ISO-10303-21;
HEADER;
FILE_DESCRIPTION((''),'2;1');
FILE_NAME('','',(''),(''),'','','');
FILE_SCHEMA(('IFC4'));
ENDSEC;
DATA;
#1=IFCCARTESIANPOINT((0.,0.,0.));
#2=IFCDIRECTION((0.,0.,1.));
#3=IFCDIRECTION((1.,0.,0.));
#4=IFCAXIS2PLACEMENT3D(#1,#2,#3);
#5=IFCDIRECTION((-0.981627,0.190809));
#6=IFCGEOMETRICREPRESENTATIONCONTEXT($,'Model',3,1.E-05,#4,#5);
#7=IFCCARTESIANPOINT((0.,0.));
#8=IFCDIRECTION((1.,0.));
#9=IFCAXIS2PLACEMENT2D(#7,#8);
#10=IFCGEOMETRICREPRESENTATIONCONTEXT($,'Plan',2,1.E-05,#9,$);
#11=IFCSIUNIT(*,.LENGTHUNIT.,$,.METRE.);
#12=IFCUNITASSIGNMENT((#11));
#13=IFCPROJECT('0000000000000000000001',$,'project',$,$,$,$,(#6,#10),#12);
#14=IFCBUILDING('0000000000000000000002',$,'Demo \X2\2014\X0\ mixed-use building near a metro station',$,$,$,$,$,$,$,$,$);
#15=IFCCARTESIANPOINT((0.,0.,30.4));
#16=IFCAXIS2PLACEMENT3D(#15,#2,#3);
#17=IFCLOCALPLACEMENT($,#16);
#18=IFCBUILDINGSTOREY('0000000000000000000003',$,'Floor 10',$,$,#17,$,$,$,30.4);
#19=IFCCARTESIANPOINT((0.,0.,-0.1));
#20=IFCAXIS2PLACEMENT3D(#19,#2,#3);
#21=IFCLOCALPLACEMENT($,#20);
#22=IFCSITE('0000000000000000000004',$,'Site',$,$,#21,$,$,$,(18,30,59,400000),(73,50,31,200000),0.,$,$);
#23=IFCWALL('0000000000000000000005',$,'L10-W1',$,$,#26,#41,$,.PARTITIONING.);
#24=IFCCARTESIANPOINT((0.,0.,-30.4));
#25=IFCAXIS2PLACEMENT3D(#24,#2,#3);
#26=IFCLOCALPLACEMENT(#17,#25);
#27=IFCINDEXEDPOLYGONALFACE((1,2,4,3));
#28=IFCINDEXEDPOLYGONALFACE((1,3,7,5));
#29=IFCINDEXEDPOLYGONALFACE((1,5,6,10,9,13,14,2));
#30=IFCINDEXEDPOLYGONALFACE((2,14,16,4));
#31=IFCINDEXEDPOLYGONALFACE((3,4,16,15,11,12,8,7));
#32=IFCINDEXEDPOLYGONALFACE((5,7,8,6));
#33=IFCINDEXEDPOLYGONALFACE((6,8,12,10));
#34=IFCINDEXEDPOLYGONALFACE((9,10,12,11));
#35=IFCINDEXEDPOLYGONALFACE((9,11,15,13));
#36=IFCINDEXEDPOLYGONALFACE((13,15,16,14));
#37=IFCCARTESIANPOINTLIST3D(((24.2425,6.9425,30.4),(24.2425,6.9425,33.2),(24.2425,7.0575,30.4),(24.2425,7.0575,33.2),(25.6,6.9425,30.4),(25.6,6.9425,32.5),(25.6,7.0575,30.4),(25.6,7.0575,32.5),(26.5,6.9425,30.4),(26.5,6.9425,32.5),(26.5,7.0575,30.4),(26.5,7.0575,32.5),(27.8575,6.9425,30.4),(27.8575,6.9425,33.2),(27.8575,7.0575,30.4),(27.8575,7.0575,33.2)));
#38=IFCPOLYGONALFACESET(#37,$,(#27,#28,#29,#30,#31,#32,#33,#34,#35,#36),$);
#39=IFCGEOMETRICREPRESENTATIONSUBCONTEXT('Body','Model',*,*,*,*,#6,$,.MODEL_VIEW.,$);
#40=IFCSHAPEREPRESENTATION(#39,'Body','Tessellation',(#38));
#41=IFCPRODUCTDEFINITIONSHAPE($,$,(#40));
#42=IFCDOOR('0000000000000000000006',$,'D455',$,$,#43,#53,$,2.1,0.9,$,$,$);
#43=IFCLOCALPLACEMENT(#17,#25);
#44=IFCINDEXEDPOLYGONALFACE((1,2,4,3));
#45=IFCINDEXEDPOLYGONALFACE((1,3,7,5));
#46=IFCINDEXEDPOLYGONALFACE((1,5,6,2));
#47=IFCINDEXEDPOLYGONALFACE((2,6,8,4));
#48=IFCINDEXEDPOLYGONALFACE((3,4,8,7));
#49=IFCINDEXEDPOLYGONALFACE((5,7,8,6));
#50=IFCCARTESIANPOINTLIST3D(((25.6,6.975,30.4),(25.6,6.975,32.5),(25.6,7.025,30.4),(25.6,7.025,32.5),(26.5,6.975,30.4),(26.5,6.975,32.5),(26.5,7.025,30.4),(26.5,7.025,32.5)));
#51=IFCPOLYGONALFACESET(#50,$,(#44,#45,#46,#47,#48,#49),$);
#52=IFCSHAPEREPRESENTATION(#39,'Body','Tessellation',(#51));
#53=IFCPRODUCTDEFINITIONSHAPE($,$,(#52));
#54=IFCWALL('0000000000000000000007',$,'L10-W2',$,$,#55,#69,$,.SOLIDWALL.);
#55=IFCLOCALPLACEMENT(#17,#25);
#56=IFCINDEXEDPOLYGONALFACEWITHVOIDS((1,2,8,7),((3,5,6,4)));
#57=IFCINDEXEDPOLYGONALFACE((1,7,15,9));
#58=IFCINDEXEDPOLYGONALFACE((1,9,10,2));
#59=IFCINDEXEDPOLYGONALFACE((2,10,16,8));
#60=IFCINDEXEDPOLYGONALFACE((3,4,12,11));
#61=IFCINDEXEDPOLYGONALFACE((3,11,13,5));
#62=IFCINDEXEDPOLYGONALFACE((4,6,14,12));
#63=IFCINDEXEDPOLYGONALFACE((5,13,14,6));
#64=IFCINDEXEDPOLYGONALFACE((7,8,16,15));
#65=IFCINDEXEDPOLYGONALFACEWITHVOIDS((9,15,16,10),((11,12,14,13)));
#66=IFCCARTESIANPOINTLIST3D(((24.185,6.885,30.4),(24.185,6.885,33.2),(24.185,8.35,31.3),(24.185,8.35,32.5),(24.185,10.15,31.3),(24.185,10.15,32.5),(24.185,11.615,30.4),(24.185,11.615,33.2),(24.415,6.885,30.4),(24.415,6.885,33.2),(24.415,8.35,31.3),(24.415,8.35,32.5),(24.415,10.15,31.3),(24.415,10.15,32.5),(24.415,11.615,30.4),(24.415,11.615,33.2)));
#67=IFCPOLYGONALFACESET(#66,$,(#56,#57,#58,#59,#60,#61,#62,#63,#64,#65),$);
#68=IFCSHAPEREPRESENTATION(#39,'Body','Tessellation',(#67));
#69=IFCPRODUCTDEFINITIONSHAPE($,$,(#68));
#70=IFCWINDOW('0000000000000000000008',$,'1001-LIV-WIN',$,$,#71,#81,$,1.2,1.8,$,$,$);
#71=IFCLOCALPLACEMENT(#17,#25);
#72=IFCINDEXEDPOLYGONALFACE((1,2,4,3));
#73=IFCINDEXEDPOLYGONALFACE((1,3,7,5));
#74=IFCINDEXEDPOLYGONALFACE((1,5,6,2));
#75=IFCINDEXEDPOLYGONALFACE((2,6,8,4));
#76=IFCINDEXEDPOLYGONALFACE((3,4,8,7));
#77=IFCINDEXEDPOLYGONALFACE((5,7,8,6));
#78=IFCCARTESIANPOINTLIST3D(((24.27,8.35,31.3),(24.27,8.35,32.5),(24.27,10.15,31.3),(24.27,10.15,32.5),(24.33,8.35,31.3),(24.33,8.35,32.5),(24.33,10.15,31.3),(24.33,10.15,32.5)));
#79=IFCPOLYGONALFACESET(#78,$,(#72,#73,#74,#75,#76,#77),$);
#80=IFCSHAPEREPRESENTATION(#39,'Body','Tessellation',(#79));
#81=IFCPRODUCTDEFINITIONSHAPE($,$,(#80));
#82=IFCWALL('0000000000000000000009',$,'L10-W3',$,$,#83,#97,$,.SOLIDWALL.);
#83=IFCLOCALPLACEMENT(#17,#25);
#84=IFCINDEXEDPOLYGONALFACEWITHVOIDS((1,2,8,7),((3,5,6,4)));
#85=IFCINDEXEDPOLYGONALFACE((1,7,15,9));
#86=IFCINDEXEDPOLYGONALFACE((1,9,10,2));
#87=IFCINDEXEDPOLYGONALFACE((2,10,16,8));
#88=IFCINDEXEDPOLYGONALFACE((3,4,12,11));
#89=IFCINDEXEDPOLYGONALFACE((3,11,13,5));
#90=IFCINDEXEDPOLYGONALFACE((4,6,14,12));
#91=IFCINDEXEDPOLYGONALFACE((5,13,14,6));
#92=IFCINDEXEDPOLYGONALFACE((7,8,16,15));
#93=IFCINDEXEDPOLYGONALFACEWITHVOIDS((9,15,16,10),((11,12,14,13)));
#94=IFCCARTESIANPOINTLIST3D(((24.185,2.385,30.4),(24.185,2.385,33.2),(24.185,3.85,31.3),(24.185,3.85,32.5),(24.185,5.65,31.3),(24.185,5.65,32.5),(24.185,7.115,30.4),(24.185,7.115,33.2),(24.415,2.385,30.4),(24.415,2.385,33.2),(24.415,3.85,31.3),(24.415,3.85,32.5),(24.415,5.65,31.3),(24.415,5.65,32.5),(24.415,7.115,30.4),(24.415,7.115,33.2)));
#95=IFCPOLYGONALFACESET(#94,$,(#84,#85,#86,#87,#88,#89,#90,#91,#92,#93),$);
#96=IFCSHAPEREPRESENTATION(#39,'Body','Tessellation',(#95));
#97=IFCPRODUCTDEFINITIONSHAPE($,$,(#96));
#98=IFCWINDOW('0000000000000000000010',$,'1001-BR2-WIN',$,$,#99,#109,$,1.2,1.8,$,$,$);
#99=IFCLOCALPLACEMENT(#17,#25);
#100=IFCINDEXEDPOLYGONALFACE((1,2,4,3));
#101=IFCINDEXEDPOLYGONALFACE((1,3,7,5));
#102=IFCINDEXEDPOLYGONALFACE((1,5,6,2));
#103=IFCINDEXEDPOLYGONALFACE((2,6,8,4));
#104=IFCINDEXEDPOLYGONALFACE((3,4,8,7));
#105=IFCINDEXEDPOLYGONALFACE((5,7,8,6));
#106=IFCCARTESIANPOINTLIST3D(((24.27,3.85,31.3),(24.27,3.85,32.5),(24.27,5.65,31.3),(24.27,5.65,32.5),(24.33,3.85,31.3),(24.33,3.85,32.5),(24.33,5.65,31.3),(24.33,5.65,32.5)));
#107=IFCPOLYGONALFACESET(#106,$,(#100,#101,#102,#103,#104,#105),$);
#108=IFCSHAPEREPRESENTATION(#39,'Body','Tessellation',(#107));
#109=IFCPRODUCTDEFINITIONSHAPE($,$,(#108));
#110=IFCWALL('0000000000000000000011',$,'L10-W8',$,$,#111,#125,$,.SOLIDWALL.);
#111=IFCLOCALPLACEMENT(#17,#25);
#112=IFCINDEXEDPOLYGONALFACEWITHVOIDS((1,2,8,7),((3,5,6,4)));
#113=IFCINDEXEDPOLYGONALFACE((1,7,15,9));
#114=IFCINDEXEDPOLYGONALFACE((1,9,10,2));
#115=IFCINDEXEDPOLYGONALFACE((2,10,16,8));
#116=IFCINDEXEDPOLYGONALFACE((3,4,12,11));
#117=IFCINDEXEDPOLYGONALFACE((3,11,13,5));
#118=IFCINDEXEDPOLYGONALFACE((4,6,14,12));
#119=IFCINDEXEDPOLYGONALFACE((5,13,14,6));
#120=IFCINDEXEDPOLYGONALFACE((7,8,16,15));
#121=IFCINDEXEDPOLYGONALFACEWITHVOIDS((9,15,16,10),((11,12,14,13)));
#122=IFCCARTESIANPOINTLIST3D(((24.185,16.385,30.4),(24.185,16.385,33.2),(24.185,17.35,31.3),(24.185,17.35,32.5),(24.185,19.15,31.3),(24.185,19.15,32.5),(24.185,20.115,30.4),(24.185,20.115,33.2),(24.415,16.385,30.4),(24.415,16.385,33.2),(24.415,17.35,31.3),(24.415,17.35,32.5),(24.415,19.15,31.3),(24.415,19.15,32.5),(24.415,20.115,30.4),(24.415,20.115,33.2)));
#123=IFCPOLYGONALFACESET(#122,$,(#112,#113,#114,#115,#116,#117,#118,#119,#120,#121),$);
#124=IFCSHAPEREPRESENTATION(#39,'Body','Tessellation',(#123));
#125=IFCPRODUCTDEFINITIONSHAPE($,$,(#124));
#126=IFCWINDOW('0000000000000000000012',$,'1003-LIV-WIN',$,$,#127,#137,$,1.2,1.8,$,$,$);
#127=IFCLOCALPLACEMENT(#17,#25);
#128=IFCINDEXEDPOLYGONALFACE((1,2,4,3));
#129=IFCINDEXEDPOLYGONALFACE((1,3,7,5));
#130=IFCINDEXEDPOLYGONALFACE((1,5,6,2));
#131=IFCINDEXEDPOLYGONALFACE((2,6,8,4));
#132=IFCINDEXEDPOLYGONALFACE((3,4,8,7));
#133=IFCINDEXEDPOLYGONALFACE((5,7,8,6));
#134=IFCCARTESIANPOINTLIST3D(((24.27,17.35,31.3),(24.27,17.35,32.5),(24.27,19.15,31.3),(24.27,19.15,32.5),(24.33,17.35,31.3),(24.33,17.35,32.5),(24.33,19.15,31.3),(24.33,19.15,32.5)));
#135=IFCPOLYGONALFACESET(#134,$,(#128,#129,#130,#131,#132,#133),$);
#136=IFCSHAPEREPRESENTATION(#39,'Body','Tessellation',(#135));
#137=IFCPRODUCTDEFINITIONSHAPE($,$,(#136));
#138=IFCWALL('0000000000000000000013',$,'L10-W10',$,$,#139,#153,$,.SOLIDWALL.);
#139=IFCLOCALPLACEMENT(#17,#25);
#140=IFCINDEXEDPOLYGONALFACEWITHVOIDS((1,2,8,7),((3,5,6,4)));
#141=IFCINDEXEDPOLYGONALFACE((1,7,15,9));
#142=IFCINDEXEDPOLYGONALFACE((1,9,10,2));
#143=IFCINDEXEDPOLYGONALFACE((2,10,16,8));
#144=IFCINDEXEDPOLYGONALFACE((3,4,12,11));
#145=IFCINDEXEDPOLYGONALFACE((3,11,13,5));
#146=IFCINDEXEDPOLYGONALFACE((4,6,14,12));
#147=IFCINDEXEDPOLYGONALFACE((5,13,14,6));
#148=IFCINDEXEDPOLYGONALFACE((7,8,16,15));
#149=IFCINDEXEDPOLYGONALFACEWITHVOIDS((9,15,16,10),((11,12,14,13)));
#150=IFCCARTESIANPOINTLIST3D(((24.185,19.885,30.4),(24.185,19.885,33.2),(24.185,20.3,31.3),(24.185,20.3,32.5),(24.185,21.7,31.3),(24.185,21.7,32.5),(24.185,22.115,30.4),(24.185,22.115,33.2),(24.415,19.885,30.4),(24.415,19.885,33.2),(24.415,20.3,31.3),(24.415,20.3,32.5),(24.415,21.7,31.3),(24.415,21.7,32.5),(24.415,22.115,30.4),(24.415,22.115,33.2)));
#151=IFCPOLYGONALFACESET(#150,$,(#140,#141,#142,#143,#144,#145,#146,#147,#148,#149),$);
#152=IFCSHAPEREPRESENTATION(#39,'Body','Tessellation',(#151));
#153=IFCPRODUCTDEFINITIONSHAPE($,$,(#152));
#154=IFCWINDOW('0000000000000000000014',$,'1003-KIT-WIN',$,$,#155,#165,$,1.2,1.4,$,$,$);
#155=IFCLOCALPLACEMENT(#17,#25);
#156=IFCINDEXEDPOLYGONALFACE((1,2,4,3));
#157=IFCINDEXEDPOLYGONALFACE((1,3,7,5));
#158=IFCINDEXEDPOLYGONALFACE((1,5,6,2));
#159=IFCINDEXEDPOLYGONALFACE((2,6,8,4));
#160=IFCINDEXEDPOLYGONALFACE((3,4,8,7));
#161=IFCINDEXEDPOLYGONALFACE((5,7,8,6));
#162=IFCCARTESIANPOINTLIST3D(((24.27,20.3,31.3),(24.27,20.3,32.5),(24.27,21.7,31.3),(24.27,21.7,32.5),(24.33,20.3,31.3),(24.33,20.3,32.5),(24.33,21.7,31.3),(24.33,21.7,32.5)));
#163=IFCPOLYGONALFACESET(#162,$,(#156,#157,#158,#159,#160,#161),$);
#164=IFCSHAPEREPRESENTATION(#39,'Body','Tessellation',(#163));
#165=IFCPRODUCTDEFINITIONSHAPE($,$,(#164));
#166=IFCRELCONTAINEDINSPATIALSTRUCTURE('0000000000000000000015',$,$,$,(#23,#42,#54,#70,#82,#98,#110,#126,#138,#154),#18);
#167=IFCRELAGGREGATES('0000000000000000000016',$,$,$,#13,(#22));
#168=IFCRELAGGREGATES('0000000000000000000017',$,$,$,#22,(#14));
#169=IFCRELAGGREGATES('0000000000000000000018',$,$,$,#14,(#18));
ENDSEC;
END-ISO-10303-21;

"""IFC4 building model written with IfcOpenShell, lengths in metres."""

from ifc_helpers import new_model, si_unit, direction, frame, origin_with_axes, origin_2d_with_axis, place, context, subcontext, project, spatial, line, indexed_curve, outline, extrude, element, fill, save


model = new_model("IFC4")

# Units and contexts
model_context = context("Model", 3, precision=1e-05, world=origin_with_axes(), true_north=direction((-0.981627, 0.190809)))
plan_context = context("Plan", 2, precision=1e-05, world=origin_2d_with_axis())
body_context = subcontext(model_context, "Body", "Model", "MODEL_VIEW")
ifc_project = project(units=[si_unit("LENGTHUNIT", "METRE")], contexts=[model_context, plan_context])

# Site, building, storey
site_placement = place(None, frame((0.0, 0.0, -0.1), z_axis=(0.0, 0.0, 1.0), x_axis=(1.0, 0.0, 0.0)))
site = spatial("IfcSite", under=ifc_project, at=site_placement, Name="Site", RefLatitude=(18, 30, 59, 400000), RefLongitude=(73, 50, 31, 200000), RefElevation=0.0)
building = spatial("IfcBuilding", under=site, Name="Demo — mixed-use building near a metro station")
storey_placement = place(None, frame((0.0, 0.0, 30.4), z_axis=(0.0, 0.0, 1.0), x_axis=(1.0, 0.0, 0.0)))
storey = spatial("IfcBuildingStorey", under=building, at=storey_placement, Name="Floor 10", Elevation=30.4)

# Wall, opening, door
wall_1_placement = place(storey_placement, frame((0.0, 0.0, -30.4), z_axis=(0.0, 0.0, 1.0), x_axis=(1.0, 0.0, 0.0)))
wall_1 = element("IfcWall", 1, at=wall_1_placement, inside=storey, Name="L10-W1", PredefinedType="PARTITIONING", context=body_context, shape_type="SweptSolid", body=[
    extrude(outline(indexed_curve([(27.8575, 6.9425), (24.2425, 6.9425), (24.2425, 7.0575), (27.8575, 7.0575)], segments=[line(1, 2, 3, 4, 1)])), frame((0.0, 0.0, 30.4), z_axis=(0.0, 0.0, 1.0), x_axis=(1.0, 0.0, 0.0)), (0.0, 0.0, 1.0), 2.8),
])
opening_1_placement = place(wall_1_placement, origin_with_axes())
opening_1 = element("IfcOpeningElement", 2, at=opening_1_placement, cuts=wall_1, context=body_context, shape_type="SweptSolid", body=[
    extrude(outline(indexed_curve([(26.5, 6.8925), (25.6, 6.8925), (25.6, 7.1075), (26.5, 7.1075)], segments=[line(1, 2, 3, 4, 1)])), frame((0.0, 0.0, 30.4), z_axis=(0.0, 0.0, 1.0), x_axis=(1.0, 0.0, 0.0)), (0.0, 0.0, 1.0), 2.1),
])
door_placement = place(storey_placement, frame((0.0, 0.0, -30.4), z_axis=(0.0, 0.0, 1.0), x_axis=(1.0, 0.0, 0.0)))
door = element("IfcDoor", 3, at=door_placement, inside=storey, Name="D455", OverallHeight=2.1, OverallWidth=0.9, context=body_context, shape_type="SweptSolid", body=[
    extrude(outline(indexed_curve([(26.5, 6.975), (25.6, 6.975), (25.6, 7.025), (26.5, 7.025)], segments=[line(1, 2, 3, 4, 1)])), frame((0.0, 0.0, 30.4), z_axis=(0.0, 0.0, 1.0), x_axis=(1.0, 0.0, 0.0)), (0.0, 0.0, 1.0), 2.1),
])
fill(opening_1, door)

# Walls, openings, windows
wall_2_placement = place(storey_placement, frame((0.0, 0.0, -30.4), z_axis=(0.0, 0.0, 1.0), x_axis=(1.0, 0.0, 0.0)))
wall_2 = element("IfcWall", 4, at=wall_2_placement, inside=storey, Name="L10-W2", PredefinedType="SOLIDWALL", context=body_context, shape_type="SweptSolid", body=[
    extrude(outline(indexed_curve([(24.415, 11.615), (24.415, 6.885), (24.185, 6.885), (24.185, 11.615)], segments=[line(1, 2, 3, 4, 1)])), frame((0.0, 0.0, 30.4), z_axis=(0.0, 0.0, 1.0), x_axis=(1.0, 0.0, 0.0)), (0.0, 0.0, 1.0), 2.8),
])
opening_2_placement = place(wall_2_placement, origin_with_axes())
opening_2 = element("IfcOpeningElement", 5, at=opening_2_placement, cuts=wall_2, context=body_context, shape_type="SweptSolid", body=[
    extrude(outline(indexed_curve([(24.465, 10.15), (24.465, 8.35), (24.135, 8.35), (24.135, 10.15)], segments=[line(1, 2, 3, 4, 1)])), frame((0.0, 0.0, 31.3), z_axis=(0.0, 0.0, 1.0), x_axis=(1.0, 0.0, 0.0)), (0.0, 0.0, 1.0), 1.2),
])
window_1_placement = place(storey_placement, frame((0.0, 0.0, -30.4), z_axis=(0.0, 0.0, 1.0), x_axis=(1.0, 0.0, 0.0)))
window_1 = element("IfcWindow", 6, at=window_1_placement, inside=storey, Name="1001-LIV-WIN", OverallHeight=1.2, OverallWidth=1.8, context=body_context, shape_type="SweptSolid", body=[
    extrude(outline(indexed_curve([(24.33, 10.15), (24.33, 8.35), (24.27, 8.35), (24.27, 10.15)], segments=[line(1, 2, 3, 4, 1)])), frame((0.0, 0.0, 31.3), z_axis=(0.0, 0.0, 1.0), x_axis=(1.0, 0.0, 0.0)), (0.0, 0.0, 1.0), 1.2),
])
fill(opening_2, window_1)
wall_3_placement = place(storey_placement, frame((0.0, 0.0, -30.4), z_axis=(0.0, 0.0, 1.0), x_axis=(1.0, 0.0, 0.0)))
wall_3 = element("IfcWall", 7, at=wall_3_placement, inside=storey, Name="L10-W3", PredefinedType="SOLIDWALL", context=body_context, shape_type="SweptSolid", body=[
    extrude(outline(indexed_curve([(24.415, 7.115), (24.415, 2.385), (24.185, 2.385), (24.185, 7.115)], segments=[line(1, 2, 3, 4, 1)])), frame((0.0, 0.0, 30.4), z_axis=(0.0, 0.0, 1.0), x_axis=(1.0, 0.0, 0.0)), (0.0, 0.0, 1.0), 2.8),
])
opening_3_placement = place(wall_3_placement, origin_with_axes())
opening_3 = element("IfcOpeningElement", 8, at=opening_3_placement, cuts=wall_3, context=body_context, shape_type="SweptSolid", body=[
    extrude(outline(indexed_curve([(24.465, 5.65), (24.465, 3.85), (24.135, 3.85), (24.135, 5.65)], segments=[line(1, 2, 3, 4, 1)])), frame((0.0, 0.0, 31.3), z_axis=(0.0, 0.0, 1.0), x_axis=(1.0, 0.0, 0.0)), (0.0, 0.0, 1.0), 1.2),
])
window_2_placement = place(storey_placement, frame((0.0, 0.0, -30.4), z_axis=(0.0, 0.0, 1.0), x_axis=(1.0, 0.0, 0.0)))
window_2 = element("IfcWindow", 9, at=window_2_placement, inside=storey, Name="1001-BR2-WIN", OverallHeight=1.2, OverallWidth=1.8, context=body_context, shape_type="SweptSolid", body=[
    extrude(outline(indexed_curve([(24.33, 5.65), (24.33, 3.85), (24.27, 3.85), (24.27, 5.65)], segments=[line(1, 2, 3, 4, 1)])), frame((0.0, 0.0, 31.3), z_axis=(0.0, 0.0, 1.0), x_axis=(1.0, 0.0, 0.0)), (0.0, 0.0, 1.0), 1.2),
])
fill(opening_3, window_2)

# Wall, opening, window
wall_4_placement = place(storey_placement, frame((0.0, 0.0, -30.4), z_axis=(0.0, 0.0, 1.0), x_axis=(1.0, 0.0, 0.0)))
wall_4 = element("IfcWall", 10, at=wall_4_placement, inside=storey, Name="L10-W8", PredefinedType="SOLIDWALL", context=body_context, shape_type="SweptSolid", body=[
    extrude(outline(indexed_curve([(24.415, 20.115), (24.415, 16.385), (24.185, 16.385), (24.185, 20.115)], segments=[line(1, 2, 3, 4, 1)])), frame((0.0, 0.0, 30.4), z_axis=(0.0, 0.0, 1.0), x_axis=(1.0, 0.0, 0.0)), (0.0, 0.0, 1.0), 2.8),
])
opening_4_placement = place(wall_4_placement, origin_with_axes())
opening_4 = element("IfcOpeningElement", 11, at=opening_4_placement, cuts=wall_4, context=body_context, shape_type="SweptSolid", body=[
    extrude(outline(indexed_curve([(24.465, 19.15), (24.465, 17.35), (24.135, 17.35), (24.135, 19.15)], segments=[line(1, 2, 3, 4, 1)])), frame((0.0, 0.0, 31.3), z_axis=(0.0, 0.0, 1.0), x_axis=(1.0, 0.0, 0.0)), (0.0, 0.0, 1.0), 1.2),
])
window_3_placement = place(storey_placement, frame((0.0, 0.0, -30.4), z_axis=(0.0, 0.0, 1.0), x_axis=(1.0, 0.0, 0.0)))
window_3 = element("IfcWindow", 12, at=window_3_placement, inside=storey, Name="1003-LIV-WIN", OverallHeight=1.2, OverallWidth=1.8, context=body_context, shape_type="SweptSolid", body=[
    extrude(outline(indexed_curve([(24.33, 19.15), (24.33, 17.35), (24.27, 17.35), (24.27, 19.15)], segments=[line(1, 2, 3, 4, 1)])), frame((0.0, 0.0, 31.3), z_axis=(0.0, 0.0, 1.0), x_axis=(1.0, 0.0, 0.0)), (0.0, 0.0, 1.0), 1.2),
])
fill(opening_4, window_3)

# Wall, opening, window
wall_5_placement = place(storey_placement, frame((0.0, 0.0, -30.4), z_axis=(0.0, 0.0, 1.0), x_axis=(1.0, 0.0, 0.0)))
wall_5 = element("IfcWall", 13, at=wall_5_placement, inside=storey, Name="L10-W10", PredefinedType="SOLIDWALL", context=body_context, shape_type="SweptSolid", body=[
    extrude(outline(indexed_curve([(24.415, 22.115), (24.415, 19.885), (24.185, 19.885), (24.185, 22.115)], segments=[line(1, 2, 3, 4, 1)])), frame((0.0, 0.0, 30.4), z_axis=(0.0, 0.0, 1.0), x_axis=(1.0, 0.0, 0.0)), (0.0, 0.0, 1.0), 2.8),
])
opening_5_placement = place(wall_5_placement, origin_with_axes())
opening_5 = element("IfcOpeningElement", 14, at=opening_5_placement, cuts=wall_5, context=body_context, shape_type="SweptSolid", body=[
    extrude(outline(indexed_curve([(24.465, 21.7), (24.465, 20.3), (24.135, 20.3), (24.135, 21.7)], segments=[line(1, 2, 3, 4, 1)])), frame((0.0, 0.0, 31.3), z_axis=(0.0, 0.0, 1.0), x_axis=(1.0, 0.0, 0.0)), (0.0, 0.0, 1.0), 1.2),
])
window_4_placement = place(storey_placement, frame((0.0, 0.0, -30.4), z_axis=(0.0, 0.0, 1.0), x_axis=(1.0, 0.0, 0.0)))
window_4 = element("IfcWindow", 15, at=window_4_placement, inside=storey, Name="1003-KIT-WIN", OverallHeight=1.2, OverallWidth=1.4, context=body_context, shape_type="SweptSolid", body=[
    extrude(outline(indexed_curve([(24.33, 21.7), (24.33, 20.3), (24.27, 20.3), (24.27, 21.7)], segments=[line(1, 2, 3, 4, 1)])), frame((0.0, 0.0, 31.3), z_axis=(0.0, 0.0, 1.0), x_axis=(1.0, 0.0, 0.0)), (0.0, 0.0, 1.0), 1.2),
])
fill(opening_5, window_4)

save(model, "model.ifc")
